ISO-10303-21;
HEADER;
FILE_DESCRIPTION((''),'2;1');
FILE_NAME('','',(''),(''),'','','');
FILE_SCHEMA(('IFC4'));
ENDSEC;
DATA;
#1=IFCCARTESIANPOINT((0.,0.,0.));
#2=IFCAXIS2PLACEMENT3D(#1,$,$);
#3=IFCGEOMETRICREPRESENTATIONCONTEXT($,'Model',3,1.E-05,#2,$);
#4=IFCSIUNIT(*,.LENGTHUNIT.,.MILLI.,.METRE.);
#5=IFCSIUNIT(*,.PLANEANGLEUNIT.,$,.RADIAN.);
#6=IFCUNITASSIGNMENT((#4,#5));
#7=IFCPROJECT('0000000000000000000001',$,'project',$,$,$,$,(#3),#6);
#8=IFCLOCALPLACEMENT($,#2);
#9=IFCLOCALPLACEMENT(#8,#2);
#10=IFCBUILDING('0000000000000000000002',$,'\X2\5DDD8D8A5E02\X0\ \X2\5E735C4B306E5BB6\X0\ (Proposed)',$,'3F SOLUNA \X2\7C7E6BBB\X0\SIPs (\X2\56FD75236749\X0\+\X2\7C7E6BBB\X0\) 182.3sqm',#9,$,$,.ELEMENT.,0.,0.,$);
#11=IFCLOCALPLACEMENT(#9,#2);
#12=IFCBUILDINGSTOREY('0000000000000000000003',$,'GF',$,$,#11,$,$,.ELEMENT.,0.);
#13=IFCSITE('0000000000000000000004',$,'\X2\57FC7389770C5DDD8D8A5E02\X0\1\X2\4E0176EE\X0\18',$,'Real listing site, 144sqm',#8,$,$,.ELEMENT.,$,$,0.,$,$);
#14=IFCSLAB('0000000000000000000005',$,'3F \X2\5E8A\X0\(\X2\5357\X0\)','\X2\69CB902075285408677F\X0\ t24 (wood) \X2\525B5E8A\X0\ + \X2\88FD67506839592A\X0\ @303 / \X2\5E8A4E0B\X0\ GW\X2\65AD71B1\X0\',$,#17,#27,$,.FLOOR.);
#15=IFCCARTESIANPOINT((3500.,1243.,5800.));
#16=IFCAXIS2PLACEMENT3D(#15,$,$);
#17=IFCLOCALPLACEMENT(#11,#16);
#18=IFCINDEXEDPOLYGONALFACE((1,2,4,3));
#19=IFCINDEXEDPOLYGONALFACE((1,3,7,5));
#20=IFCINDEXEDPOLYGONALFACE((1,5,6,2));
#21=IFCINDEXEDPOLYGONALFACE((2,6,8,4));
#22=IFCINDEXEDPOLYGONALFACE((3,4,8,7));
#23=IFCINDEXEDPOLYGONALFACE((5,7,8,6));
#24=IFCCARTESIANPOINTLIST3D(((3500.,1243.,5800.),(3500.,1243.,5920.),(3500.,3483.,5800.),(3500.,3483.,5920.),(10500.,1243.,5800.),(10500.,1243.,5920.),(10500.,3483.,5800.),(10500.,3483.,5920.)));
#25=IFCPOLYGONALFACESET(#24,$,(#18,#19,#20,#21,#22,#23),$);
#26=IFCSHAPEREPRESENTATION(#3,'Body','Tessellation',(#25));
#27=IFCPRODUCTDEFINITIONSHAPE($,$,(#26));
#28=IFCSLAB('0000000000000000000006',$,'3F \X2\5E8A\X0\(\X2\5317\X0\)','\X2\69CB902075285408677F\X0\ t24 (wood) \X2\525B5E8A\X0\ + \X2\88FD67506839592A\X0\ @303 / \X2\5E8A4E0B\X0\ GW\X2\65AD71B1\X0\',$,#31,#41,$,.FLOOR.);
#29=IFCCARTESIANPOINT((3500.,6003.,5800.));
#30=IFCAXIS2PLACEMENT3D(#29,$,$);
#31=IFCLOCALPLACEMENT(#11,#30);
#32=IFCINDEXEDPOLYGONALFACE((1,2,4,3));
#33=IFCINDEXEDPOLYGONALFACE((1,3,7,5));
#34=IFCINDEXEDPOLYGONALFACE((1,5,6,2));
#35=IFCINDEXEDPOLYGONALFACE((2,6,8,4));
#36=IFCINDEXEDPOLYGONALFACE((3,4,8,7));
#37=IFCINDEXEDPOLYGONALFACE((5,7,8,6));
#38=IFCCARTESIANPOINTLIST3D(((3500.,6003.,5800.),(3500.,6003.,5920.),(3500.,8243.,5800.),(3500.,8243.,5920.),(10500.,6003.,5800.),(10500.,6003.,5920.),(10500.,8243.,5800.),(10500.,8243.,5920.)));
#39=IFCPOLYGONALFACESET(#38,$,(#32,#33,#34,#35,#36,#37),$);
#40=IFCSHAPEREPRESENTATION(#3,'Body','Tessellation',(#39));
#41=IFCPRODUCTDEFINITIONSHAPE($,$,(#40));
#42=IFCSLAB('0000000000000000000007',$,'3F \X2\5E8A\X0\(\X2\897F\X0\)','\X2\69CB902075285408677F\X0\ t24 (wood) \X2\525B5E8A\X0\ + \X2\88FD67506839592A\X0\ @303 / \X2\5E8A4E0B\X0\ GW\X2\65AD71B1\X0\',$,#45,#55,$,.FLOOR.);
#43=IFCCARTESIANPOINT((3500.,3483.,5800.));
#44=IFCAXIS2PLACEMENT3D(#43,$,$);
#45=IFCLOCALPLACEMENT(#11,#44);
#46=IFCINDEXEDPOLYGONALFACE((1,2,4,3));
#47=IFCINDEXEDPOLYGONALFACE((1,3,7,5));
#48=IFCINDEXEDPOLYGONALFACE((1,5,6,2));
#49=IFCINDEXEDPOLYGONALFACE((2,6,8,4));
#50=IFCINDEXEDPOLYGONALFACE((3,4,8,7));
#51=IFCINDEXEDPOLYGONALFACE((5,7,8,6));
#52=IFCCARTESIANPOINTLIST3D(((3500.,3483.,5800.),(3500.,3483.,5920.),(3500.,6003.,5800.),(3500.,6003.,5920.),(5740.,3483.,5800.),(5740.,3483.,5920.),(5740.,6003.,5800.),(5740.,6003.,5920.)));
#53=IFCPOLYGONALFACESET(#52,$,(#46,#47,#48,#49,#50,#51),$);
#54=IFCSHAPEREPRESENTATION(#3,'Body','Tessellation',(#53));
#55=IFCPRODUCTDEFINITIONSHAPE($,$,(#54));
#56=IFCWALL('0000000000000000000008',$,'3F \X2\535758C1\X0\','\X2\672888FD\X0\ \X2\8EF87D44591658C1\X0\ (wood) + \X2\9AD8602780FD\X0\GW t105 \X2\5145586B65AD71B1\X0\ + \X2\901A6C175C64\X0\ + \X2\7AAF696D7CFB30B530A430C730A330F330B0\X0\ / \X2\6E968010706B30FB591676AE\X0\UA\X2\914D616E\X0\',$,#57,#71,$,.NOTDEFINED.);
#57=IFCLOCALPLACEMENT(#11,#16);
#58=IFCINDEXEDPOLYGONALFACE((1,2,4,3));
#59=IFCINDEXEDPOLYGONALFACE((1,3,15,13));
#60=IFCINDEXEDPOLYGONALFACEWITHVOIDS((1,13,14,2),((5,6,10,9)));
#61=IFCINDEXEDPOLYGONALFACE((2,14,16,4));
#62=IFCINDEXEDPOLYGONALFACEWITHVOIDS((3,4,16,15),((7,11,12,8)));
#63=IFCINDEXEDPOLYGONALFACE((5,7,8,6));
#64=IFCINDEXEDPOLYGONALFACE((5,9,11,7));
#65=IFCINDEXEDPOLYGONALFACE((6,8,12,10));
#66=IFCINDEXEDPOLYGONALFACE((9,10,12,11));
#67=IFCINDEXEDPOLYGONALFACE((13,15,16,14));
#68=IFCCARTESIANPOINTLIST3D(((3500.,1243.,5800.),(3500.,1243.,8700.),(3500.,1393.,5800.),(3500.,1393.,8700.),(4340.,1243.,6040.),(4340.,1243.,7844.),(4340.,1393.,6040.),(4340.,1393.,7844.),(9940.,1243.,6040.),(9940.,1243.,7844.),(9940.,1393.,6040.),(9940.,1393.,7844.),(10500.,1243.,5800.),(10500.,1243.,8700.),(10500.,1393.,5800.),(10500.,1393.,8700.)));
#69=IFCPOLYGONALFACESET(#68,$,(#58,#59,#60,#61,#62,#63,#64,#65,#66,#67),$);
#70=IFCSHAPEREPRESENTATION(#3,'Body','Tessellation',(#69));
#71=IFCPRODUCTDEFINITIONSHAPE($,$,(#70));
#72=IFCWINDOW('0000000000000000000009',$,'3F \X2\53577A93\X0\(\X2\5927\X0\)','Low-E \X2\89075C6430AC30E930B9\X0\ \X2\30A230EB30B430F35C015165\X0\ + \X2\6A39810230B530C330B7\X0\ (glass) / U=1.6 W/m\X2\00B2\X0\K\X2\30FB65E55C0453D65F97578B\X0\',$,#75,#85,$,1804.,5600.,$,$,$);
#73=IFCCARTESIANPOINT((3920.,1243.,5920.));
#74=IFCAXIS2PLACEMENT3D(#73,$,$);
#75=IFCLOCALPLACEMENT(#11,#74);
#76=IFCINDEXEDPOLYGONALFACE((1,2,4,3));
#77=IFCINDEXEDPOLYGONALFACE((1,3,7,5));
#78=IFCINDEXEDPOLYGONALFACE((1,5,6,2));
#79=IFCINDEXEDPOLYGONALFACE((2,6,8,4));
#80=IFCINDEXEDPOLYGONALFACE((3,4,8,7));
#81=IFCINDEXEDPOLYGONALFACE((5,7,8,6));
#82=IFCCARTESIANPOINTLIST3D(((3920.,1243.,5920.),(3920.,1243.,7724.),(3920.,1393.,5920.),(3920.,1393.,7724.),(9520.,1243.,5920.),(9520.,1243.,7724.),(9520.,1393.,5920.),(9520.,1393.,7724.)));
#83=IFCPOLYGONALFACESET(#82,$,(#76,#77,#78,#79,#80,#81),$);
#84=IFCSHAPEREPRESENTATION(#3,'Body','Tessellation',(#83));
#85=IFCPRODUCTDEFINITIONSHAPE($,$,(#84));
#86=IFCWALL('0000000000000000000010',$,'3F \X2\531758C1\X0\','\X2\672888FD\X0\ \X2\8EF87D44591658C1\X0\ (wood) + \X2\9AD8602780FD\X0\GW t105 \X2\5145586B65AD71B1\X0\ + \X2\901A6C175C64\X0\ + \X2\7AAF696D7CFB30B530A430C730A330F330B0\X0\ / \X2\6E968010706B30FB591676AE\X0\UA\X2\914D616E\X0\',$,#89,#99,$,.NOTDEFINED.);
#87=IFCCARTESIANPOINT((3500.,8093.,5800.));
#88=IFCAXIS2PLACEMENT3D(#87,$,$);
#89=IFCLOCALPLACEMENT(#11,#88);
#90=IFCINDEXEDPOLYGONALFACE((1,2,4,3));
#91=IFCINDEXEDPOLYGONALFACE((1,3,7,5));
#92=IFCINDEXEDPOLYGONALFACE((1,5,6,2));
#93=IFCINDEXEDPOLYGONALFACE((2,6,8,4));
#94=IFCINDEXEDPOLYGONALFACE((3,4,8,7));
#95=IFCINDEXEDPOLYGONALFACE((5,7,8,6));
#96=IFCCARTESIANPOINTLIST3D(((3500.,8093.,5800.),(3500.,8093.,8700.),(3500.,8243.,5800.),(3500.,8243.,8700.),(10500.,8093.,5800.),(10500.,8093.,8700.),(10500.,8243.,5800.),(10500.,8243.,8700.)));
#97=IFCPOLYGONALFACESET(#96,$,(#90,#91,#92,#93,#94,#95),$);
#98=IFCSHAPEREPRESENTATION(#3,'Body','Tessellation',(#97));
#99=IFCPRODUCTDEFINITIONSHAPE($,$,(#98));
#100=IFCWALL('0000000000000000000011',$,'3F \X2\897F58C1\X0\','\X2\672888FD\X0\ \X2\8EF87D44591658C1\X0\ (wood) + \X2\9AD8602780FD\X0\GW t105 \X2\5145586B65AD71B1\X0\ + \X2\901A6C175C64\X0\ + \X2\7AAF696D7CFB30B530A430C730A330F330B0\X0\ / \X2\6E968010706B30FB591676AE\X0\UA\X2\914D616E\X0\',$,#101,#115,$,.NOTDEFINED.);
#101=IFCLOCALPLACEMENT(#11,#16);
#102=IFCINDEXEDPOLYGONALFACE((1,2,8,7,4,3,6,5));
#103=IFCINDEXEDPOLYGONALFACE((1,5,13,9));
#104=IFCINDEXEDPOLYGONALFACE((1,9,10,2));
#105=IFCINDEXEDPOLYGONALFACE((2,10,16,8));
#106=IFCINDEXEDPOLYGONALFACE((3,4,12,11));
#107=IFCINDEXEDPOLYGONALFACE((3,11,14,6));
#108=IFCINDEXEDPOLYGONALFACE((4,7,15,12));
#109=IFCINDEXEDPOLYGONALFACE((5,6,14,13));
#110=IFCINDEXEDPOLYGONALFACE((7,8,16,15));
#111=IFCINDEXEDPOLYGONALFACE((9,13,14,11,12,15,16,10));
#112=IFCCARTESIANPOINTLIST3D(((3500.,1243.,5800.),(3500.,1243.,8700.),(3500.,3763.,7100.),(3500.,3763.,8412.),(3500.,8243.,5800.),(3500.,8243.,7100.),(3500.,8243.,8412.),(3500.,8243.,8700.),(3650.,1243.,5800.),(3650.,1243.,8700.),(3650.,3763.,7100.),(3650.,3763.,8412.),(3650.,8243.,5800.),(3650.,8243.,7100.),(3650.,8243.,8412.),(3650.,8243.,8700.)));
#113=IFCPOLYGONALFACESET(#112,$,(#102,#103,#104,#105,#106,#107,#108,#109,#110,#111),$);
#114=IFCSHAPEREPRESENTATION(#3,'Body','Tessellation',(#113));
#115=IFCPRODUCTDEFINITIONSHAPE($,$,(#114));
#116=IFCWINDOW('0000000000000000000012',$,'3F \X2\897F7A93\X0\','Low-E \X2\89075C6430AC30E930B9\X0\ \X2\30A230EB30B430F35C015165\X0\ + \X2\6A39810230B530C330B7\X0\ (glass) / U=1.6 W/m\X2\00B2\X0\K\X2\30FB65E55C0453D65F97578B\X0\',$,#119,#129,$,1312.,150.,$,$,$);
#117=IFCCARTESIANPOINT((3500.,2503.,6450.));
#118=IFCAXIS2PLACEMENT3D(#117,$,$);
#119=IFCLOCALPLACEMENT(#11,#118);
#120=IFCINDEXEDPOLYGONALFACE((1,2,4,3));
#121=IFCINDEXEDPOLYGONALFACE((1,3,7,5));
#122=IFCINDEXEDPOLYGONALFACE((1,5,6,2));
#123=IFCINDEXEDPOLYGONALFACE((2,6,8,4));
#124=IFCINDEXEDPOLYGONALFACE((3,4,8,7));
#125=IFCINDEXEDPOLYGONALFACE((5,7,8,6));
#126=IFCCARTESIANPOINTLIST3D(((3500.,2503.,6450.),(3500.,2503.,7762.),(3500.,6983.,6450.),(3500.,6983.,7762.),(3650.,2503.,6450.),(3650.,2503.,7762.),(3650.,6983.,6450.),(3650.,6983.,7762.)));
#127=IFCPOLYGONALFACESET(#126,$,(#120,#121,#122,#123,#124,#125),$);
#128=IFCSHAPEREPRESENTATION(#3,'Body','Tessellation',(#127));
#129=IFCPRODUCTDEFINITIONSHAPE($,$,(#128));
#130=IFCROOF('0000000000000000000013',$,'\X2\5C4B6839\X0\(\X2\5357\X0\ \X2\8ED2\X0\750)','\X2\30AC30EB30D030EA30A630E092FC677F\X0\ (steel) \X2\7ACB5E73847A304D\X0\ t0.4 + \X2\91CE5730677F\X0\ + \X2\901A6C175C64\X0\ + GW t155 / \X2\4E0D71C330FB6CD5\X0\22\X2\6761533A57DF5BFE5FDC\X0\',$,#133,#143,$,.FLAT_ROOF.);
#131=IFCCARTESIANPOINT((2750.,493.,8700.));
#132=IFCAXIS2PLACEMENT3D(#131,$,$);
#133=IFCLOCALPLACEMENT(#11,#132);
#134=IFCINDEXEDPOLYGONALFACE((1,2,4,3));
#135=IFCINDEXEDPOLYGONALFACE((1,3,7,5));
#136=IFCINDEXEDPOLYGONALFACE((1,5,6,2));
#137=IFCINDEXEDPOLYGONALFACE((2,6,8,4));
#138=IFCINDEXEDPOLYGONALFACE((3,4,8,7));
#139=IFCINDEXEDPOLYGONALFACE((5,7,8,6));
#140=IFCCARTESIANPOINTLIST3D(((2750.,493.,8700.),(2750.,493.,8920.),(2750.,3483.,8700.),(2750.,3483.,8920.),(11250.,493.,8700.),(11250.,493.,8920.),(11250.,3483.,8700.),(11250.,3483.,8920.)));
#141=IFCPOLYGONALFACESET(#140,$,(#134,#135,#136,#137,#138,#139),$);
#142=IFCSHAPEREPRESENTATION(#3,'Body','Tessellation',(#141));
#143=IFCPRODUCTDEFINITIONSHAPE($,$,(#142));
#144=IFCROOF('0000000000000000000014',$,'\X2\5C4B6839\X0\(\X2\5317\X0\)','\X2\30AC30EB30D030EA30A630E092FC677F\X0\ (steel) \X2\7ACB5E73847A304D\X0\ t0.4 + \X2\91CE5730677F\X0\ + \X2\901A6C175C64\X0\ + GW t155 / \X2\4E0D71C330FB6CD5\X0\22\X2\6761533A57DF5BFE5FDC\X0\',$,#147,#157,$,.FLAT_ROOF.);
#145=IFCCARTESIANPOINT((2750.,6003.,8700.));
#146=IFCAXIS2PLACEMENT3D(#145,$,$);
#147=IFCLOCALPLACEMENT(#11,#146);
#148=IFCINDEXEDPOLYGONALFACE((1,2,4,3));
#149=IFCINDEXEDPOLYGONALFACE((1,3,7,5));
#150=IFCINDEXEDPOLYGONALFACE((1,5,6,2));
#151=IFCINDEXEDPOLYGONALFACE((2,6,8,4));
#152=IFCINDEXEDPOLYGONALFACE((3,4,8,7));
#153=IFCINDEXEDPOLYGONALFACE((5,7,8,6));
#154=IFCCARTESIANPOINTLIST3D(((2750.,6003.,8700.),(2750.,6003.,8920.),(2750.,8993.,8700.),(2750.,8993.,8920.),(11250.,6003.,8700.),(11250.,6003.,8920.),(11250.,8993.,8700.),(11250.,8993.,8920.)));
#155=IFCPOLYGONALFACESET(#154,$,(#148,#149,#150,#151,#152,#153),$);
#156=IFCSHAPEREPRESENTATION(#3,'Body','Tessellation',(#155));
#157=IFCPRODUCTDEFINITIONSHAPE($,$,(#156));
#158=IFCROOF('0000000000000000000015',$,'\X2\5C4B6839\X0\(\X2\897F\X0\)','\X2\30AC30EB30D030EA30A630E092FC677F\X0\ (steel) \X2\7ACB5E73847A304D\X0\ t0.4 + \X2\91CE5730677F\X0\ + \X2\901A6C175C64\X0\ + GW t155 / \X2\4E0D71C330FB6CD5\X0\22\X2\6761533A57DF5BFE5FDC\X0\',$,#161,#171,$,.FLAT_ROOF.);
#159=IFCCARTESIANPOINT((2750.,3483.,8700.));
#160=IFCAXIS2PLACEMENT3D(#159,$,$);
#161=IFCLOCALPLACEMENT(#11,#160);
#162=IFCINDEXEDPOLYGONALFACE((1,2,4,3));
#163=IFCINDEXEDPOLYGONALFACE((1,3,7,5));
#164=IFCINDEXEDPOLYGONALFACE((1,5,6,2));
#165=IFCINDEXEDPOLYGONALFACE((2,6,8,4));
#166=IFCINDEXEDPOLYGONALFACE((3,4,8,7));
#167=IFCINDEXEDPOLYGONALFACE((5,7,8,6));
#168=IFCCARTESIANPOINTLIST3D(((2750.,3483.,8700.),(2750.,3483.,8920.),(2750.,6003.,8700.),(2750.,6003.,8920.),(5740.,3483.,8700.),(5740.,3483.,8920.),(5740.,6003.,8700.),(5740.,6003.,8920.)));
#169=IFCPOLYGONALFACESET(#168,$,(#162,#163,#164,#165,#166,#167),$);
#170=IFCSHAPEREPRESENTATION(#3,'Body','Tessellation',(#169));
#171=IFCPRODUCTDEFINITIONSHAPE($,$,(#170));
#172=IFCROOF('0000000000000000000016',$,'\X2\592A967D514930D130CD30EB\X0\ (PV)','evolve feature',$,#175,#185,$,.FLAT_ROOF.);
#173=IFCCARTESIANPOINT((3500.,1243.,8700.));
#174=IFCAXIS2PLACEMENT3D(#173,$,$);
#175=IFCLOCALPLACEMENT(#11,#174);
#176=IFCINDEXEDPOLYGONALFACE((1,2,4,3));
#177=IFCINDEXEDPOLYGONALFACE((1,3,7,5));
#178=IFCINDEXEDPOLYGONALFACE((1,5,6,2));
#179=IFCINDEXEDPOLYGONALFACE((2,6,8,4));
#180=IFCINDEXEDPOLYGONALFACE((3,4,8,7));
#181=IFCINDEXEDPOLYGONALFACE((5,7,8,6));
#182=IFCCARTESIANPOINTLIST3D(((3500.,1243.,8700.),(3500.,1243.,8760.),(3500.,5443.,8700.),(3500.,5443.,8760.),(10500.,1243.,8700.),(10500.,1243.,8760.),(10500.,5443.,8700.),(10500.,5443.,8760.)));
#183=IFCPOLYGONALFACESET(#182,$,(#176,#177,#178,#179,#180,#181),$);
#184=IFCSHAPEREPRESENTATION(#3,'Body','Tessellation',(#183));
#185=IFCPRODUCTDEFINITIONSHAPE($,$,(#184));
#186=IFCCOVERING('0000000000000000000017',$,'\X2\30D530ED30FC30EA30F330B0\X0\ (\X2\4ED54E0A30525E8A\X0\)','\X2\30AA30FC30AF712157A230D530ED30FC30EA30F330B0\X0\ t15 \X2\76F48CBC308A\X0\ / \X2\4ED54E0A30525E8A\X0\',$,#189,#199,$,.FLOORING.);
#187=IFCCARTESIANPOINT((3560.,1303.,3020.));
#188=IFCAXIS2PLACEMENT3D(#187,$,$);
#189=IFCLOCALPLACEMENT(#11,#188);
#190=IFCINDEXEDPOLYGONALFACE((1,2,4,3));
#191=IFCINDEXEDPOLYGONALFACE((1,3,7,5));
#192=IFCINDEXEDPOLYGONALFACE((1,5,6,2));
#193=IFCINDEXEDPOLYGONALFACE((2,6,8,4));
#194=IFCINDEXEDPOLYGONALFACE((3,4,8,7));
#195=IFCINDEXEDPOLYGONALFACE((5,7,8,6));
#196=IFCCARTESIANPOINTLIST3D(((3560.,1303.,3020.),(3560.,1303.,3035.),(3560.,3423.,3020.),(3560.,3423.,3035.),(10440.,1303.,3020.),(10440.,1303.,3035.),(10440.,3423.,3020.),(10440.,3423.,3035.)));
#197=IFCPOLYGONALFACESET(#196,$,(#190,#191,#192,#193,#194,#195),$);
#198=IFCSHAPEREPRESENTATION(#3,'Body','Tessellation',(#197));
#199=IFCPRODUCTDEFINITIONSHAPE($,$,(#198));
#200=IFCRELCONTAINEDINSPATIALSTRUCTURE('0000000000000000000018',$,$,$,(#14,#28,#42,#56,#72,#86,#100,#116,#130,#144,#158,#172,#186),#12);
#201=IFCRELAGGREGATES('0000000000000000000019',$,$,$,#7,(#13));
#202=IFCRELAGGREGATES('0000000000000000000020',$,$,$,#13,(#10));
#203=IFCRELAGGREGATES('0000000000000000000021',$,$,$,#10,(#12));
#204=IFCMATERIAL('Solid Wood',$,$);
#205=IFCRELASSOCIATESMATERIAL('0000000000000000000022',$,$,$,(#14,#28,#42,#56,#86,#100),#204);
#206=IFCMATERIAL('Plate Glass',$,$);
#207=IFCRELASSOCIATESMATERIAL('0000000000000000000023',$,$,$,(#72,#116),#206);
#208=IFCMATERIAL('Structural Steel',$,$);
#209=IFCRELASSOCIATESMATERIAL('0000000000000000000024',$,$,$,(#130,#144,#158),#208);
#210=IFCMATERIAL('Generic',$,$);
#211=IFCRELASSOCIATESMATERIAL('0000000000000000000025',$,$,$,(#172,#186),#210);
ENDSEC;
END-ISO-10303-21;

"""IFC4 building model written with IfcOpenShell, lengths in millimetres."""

from ifc_helpers import new_model, si_unit, frame, frame_2d, origin, place, context, project, spatial, rectangle, extrude, material, element, fill, save


model = new_model("IFC4")

# Units and contexts
model_context = context("Model", 3, precision=1e-05, world=origin())
ifc_project = project(units=[si_unit("LENGTHUNIT", "METRE", prefix="MILLI"), si_unit("PLANEANGLEUNIT", "RADIAN")], contexts=[model_context])

# Site, building, storey
site_placement = place(None, origin())
site = spatial("IfcSite", under=ifc_project, at=site_placement, Name="埼玉県川越市1丁目18", ObjectType="Real listing site, 144sqm", CompositionType="ELEMENT", RefElevation=0.0)
building_placement = place(site_placement, origin())
building = spatial("IfcBuilding", under=site, at=building_placement, Name="川越市 平屋の家 (Proposed)", ObjectType="3F SOLUNA 籾殻SIPs (国産杉+籾殻) 182.3sqm", CompositionType="ELEMENT", ElevationOfRefHeight=0.0, ElevationOfTerrain=0.0)
storey_placement = place(building_placement, origin())
storey = spatial("IfcBuildingStorey", under=building, at=storey_placement, Name="GF", CompositionType="ELEMENT", Elevation=0.0)

# Slabs
ifc_material_1 = material(Name="Solid Wood")
slab_1_placement = place(storey_placement, frame((3500.0, 1243.0, 5800.0)))
element("IfcSlab", 1, at=slab_1_placement, inside=storey, material=ifc_material_1, Name="3F 床(南)", Description="構造用合板 t24 (wood) 剛床 + 製材根太 @303 / 床下 GW断熱", PredefinedType="FLOOR", context=model_context, shape_type="SweptSolid", body=[
    extrude(rectangle(XDim=7000.0, YDim=2240.0, at=frame_2d((3500.0, 1120.0))), frame((3500.0, 1243.0, 5800.0)), (0.0, 0.0, 1.0), 120.0),
])
slab_2_placement = place(storey_placement, frame((3500.0, 6003.0, 5800.0)))
element("IfcSlab", 2, at=slab_2_placement, inside=storey, material=ifc_material_1, Name="3F 床(北)", Description="構造用合板 t24 (wood) 剛床 + 製材根太 @303 / 床下 GW断熱", PredefinedType="FLOOR", context=model_context, shape_type="SweptSolid", body=[
    extrude(rectangle(XDim=7000.0, YDim=2240.0, at=frame_2d((3500.0, 1120.0))), frame((3500.0, 6003.0, 5800.0)), (0.0, 0.0, 1.0), 120.0),
])
slab_3_placement = place(storey_placement, frame((3500.0, 3483.0, 5800.0)))
element("IfcSlab", 3, at=slab_3_placement, inside=storey, material=ifc_material_1, Name="3F 床(西)", Description="構造用合板 t24 (wood) 剛床 + 製材根太 @303 / 床下 GW断熱", PredefinedType="FLOOR", context=model_context, shape_type="SweptSolid", body=[
    extrude(rectangle(XDim=2240.0, YDim=2520.0, at=frame_2d((1120.0, 1260.0))), frame((3500.0, 3483.0, 5800.0)), (0.0, 0.0, 1.0), 120.0),
])

# Wall, opening, window
wall_1_placement = place(storey_placement, frame((3500.0, 1243.0, 5800.0)))
wall_1 = element("IfcWall", 4, at=wall_1_placement, inside=storey, material=ifc_material_1, Name="3F 南壁", Description="木製 軸組外壁 (wood) + 高性能GW t105 充填断熱 + 通気層 + 窯業系サイディング / 準耐火・外皮UA配慮", PredefinedType="NOTDEFINED", context=model_context, shape_type="SweptSolid", body=[
    extrude(rectangle(XDim=7000.0, YDim=150.0, at=frame_2d((3500.0, 75.0))), frame((3500.0, 1243.0, 5800.0)), (0.0, 0.0, 1.0), 2900.0),
])
opening_1_placement = place(storey_placement, frame((3920.0, 1243.0, 5920.0)))
opening_1 = element("IfcOpeningElement", 5, at=opening_1_placement, cuts=wall_1, PredefinedType="NOTDEFINED", context=model_context, shape_type="SweptSolid", body=[
    extrude(rectangle(XDim=5600.0, YDim=150.0, at=frame_2d((2800.0, 75.0))), frame((3920.0, 1243.0, 5920.0)), (0.0, 0.0, 1.0), 1804.0),
])
ifc_material_2 = material(Name="Plate Glass")
window_1_placement = place(storey_placement, frame((3920.0, 1243.0, 5920.0)))
window_1 = element("IfcWindow", 6, at=window_1_placement, inside=storey, material=ifc_material_2, Name="3F 南窓(大)", Description="Low-E 複層ガラス アルゴン封入 + 樹脂サッシ (glass) / U=1.6 W/m²K・日射取得型", OverallHeight=1804.0, OverallWidth=5600.0, context=model_context, shape_type="SweptSolid", body=[
    extrude(rectangle(XDim=5600.0, YDim=150.0, at=frame_2d((2800.0, 75.0))), frame((3920.0, 1243.0, 5920.0)), (0.0, 0.0, 1.0), 1804.0),
])
fill(opening_1, window_1)

# Wall
wall_2_placement = place(storey_placement, frame((3500.0, 8093.0, 5800.0)))
element("IfcWall", 7, at=wall_2_placement, inside=storey, material=ifc_material_1, Name="3F 北壁", Description="木製 軸組外壁 (wood) + 高性能GW t105 充填断熱 + 通気層 + 窯業系サイディング / 準耐火・外皮UA配慮", PredefinedType="NOTDEFINED", context=model_context, shape_type="SweptSolid", body=[
    extrude(rectangle(XDim=7000.0, YDim=150.0, at=frame_2d((3500.0, 75.0))), frame((3500.0, 8093.0, 5800.0)), (0.0, 0.0, 1.0), 2900.0),
])

# Wall, opening, window
wall_3_placement = place(storey_placement, frame((3500.0, 1243.0, 5800.0)))
wall_3 = element("IfcWall", 8, at=wall_3_placement, inside=storey, material=ifc_material_1, Name="3F 西壁", Description="木製 軸組外壁 (wood) + 高性能GW t105 充填断熱 + 通気層 + 窯業系サイディング / 準耐火・外皮UA配慮", PredefinedType="NOTDEFINED", context=model_context, shape_type="SweptSolid", body=[
    extrude(rectangle(XDim=150.0, YDim=7000.0, at=frame_2d((75.0, 3500.0))), frame((3500.0, 1243.0, 5800.0)), (0.0, 0.0, 1.0), 2900.0),
])
opening_2_placement = place(storey_placement, frame((3500.0, 2503.0, 6450.0)))
opening_2 = element("IfcOpeningElement", 9, at=opening_2_placement, cuts=wall_3, PredefinedType="NOTDEFINED", context=model_context, shape_type="SweptSolid", body=[
    extrude(rectangle(XDim=150.0, YDim=4480.0, at=frame_2d((75.0, 2240.0))), frame((3500.0, 2503.0, 6450.0)), (0.0, 0.0, 1.0), 1312.0),
])
window_2_placement = place(storey_placement, frame((3500.0, 2503.0, 6450.0)))
window_2 = element("IfcWindow", 10, at=window_2_placement, inside=storey, material=ifc_material_2, Name="3F 西窓", Description="Low-E 複層ガラス アルゴン封入 + 樹脂サッシ (glass) / U=1.6 W/m²K・日射取得型", OverallHeight=1312.0, OverallWidth=150.0, context=model_context, shape_type="SweptSolid", body=[
    extrude(rectangle(XDim=150.0, YDim=4480.0, at=frame_2d((75.0, 2240.0))), frame((3500.0, 2503.0, 6450.0)), (0.0, 0.0, 1.0), 1312.0),
])
fill(opening_2, window_2)

# Roofs
ifc_material_3 = material(Name="Structural Steel")
roof_1_placement = place(storey_placement, frame((2750.0, 493.0, 8700.0)))
element("IfcRoof", 11, at=roof_1_placement, inside=storey, material=ifc_material_3, Name="屋根(南 軒750)", Description="ガルバリウム鋼板 (steel) 立平葺き t0.4 + 野地板 + 通気層 + GW t155 / 不燃・法22条区域対応", PredefinedType="FLAT_ROOF", context=model_context, shape_type="SweptSolid", body=[
    extrude(rectangle(XDim=8500.0, YDim=2990.0, at=frame_2d((4250.0, 1495.0))), frame((2750.0, 493.0, 8700.0)), (0.0, 0.0, 1.0), 220.0),
])
roof_2_placement = place(storey_placement, frame((2750.0, 6003.0, 8700.0)))
element("IfcRoof", 12, at=roof_2_placement, inside=storey, material=ifc_material_3, Name="屋根(北)", Description="ガルバリウム鋼板 (steel) 立平葺き t0.4 + 野地板 + 通気層 + GW t155 / 不燃・法22条区域対応", PredefinedType="FLAT_ROOF", context=model_context, shape_type="SweptSolid", body=[
    extrude(rectangle(XDim=8500.0, YDim=2990.0, at=frame_2d((4250.0, 1495.0))), frame((2750.0, 6003.0, 8700.0)), (0.0, 0.0, 1.0), 220.0),
])
roof_3_placement = place(storey_placement, frame((2750.0, 3483.0, 8700.0)))
element("IfcRoof", 13, at=roof_3_placement, inside=storey, material=ifc_material_3, Name="屋根(西)", Description="ガルバリウム鋼板 (steel) 立平葺き t0.4 + 野地板 + 通気層 + GW t155 / 不燃・法22条区域対応", PredefinedType="FLAT_ROOF", context=model_context, shape_type="SweptSolid", body=[
    extrude(rectangle(XDim=2990.0, YDim=2520.0, at=frame_2d((1495.0, 1260.0))), frame((2750.0, 3483.0, 8700.0)), (0.0, 0.0, 1.0), 220.0),
])
ifc_material_4 = material(Name="Generic")
roof_4_placement = place(storey_placement, frame((3500.0, 1243.0, 8700.0)))
element("IfcRoof", 14, at=roof_4_placement, inside=storey, material=ifc_material_4, Name="太陽光パネル (PV)", Description="evolve feature", PredefinedType="FLAT_ROOF", context=model_context, shape_type="SweptSolid", body=[
    extrude(rectangle(XDim=7000.0, YDim=4200.0, at=frame_2d((3500.0, 2100.0))), frame((3500.0, 1243.0, 8700.0)), (0.0, 0.0, 1.0), 60.0),
])

# Covering
covering_1_placement = place(storey_placement, frame((3560.0, 1303.0, 3020.0)))
element("IfcCovering", 15, at=covering_1_placement, inside=storey, material=ifc_material_4, Name="フローリング (仕上げ床)", Description="オーク無垢フローリング t15 直貼り / 仕上げ床", PredefinedType="FLOORING", context=model_context, shape_type="SweptSolid", body=[
    extrude(rectangle(XDim=6880.0, YDim=2120.0, at=frame_2d((3440.0, 1060.0))), frame((3560.0, 1303.0, 3020.0)), (0.0, 0.0, 1.0), 15.0),
])

save(model, "model.ifc")
